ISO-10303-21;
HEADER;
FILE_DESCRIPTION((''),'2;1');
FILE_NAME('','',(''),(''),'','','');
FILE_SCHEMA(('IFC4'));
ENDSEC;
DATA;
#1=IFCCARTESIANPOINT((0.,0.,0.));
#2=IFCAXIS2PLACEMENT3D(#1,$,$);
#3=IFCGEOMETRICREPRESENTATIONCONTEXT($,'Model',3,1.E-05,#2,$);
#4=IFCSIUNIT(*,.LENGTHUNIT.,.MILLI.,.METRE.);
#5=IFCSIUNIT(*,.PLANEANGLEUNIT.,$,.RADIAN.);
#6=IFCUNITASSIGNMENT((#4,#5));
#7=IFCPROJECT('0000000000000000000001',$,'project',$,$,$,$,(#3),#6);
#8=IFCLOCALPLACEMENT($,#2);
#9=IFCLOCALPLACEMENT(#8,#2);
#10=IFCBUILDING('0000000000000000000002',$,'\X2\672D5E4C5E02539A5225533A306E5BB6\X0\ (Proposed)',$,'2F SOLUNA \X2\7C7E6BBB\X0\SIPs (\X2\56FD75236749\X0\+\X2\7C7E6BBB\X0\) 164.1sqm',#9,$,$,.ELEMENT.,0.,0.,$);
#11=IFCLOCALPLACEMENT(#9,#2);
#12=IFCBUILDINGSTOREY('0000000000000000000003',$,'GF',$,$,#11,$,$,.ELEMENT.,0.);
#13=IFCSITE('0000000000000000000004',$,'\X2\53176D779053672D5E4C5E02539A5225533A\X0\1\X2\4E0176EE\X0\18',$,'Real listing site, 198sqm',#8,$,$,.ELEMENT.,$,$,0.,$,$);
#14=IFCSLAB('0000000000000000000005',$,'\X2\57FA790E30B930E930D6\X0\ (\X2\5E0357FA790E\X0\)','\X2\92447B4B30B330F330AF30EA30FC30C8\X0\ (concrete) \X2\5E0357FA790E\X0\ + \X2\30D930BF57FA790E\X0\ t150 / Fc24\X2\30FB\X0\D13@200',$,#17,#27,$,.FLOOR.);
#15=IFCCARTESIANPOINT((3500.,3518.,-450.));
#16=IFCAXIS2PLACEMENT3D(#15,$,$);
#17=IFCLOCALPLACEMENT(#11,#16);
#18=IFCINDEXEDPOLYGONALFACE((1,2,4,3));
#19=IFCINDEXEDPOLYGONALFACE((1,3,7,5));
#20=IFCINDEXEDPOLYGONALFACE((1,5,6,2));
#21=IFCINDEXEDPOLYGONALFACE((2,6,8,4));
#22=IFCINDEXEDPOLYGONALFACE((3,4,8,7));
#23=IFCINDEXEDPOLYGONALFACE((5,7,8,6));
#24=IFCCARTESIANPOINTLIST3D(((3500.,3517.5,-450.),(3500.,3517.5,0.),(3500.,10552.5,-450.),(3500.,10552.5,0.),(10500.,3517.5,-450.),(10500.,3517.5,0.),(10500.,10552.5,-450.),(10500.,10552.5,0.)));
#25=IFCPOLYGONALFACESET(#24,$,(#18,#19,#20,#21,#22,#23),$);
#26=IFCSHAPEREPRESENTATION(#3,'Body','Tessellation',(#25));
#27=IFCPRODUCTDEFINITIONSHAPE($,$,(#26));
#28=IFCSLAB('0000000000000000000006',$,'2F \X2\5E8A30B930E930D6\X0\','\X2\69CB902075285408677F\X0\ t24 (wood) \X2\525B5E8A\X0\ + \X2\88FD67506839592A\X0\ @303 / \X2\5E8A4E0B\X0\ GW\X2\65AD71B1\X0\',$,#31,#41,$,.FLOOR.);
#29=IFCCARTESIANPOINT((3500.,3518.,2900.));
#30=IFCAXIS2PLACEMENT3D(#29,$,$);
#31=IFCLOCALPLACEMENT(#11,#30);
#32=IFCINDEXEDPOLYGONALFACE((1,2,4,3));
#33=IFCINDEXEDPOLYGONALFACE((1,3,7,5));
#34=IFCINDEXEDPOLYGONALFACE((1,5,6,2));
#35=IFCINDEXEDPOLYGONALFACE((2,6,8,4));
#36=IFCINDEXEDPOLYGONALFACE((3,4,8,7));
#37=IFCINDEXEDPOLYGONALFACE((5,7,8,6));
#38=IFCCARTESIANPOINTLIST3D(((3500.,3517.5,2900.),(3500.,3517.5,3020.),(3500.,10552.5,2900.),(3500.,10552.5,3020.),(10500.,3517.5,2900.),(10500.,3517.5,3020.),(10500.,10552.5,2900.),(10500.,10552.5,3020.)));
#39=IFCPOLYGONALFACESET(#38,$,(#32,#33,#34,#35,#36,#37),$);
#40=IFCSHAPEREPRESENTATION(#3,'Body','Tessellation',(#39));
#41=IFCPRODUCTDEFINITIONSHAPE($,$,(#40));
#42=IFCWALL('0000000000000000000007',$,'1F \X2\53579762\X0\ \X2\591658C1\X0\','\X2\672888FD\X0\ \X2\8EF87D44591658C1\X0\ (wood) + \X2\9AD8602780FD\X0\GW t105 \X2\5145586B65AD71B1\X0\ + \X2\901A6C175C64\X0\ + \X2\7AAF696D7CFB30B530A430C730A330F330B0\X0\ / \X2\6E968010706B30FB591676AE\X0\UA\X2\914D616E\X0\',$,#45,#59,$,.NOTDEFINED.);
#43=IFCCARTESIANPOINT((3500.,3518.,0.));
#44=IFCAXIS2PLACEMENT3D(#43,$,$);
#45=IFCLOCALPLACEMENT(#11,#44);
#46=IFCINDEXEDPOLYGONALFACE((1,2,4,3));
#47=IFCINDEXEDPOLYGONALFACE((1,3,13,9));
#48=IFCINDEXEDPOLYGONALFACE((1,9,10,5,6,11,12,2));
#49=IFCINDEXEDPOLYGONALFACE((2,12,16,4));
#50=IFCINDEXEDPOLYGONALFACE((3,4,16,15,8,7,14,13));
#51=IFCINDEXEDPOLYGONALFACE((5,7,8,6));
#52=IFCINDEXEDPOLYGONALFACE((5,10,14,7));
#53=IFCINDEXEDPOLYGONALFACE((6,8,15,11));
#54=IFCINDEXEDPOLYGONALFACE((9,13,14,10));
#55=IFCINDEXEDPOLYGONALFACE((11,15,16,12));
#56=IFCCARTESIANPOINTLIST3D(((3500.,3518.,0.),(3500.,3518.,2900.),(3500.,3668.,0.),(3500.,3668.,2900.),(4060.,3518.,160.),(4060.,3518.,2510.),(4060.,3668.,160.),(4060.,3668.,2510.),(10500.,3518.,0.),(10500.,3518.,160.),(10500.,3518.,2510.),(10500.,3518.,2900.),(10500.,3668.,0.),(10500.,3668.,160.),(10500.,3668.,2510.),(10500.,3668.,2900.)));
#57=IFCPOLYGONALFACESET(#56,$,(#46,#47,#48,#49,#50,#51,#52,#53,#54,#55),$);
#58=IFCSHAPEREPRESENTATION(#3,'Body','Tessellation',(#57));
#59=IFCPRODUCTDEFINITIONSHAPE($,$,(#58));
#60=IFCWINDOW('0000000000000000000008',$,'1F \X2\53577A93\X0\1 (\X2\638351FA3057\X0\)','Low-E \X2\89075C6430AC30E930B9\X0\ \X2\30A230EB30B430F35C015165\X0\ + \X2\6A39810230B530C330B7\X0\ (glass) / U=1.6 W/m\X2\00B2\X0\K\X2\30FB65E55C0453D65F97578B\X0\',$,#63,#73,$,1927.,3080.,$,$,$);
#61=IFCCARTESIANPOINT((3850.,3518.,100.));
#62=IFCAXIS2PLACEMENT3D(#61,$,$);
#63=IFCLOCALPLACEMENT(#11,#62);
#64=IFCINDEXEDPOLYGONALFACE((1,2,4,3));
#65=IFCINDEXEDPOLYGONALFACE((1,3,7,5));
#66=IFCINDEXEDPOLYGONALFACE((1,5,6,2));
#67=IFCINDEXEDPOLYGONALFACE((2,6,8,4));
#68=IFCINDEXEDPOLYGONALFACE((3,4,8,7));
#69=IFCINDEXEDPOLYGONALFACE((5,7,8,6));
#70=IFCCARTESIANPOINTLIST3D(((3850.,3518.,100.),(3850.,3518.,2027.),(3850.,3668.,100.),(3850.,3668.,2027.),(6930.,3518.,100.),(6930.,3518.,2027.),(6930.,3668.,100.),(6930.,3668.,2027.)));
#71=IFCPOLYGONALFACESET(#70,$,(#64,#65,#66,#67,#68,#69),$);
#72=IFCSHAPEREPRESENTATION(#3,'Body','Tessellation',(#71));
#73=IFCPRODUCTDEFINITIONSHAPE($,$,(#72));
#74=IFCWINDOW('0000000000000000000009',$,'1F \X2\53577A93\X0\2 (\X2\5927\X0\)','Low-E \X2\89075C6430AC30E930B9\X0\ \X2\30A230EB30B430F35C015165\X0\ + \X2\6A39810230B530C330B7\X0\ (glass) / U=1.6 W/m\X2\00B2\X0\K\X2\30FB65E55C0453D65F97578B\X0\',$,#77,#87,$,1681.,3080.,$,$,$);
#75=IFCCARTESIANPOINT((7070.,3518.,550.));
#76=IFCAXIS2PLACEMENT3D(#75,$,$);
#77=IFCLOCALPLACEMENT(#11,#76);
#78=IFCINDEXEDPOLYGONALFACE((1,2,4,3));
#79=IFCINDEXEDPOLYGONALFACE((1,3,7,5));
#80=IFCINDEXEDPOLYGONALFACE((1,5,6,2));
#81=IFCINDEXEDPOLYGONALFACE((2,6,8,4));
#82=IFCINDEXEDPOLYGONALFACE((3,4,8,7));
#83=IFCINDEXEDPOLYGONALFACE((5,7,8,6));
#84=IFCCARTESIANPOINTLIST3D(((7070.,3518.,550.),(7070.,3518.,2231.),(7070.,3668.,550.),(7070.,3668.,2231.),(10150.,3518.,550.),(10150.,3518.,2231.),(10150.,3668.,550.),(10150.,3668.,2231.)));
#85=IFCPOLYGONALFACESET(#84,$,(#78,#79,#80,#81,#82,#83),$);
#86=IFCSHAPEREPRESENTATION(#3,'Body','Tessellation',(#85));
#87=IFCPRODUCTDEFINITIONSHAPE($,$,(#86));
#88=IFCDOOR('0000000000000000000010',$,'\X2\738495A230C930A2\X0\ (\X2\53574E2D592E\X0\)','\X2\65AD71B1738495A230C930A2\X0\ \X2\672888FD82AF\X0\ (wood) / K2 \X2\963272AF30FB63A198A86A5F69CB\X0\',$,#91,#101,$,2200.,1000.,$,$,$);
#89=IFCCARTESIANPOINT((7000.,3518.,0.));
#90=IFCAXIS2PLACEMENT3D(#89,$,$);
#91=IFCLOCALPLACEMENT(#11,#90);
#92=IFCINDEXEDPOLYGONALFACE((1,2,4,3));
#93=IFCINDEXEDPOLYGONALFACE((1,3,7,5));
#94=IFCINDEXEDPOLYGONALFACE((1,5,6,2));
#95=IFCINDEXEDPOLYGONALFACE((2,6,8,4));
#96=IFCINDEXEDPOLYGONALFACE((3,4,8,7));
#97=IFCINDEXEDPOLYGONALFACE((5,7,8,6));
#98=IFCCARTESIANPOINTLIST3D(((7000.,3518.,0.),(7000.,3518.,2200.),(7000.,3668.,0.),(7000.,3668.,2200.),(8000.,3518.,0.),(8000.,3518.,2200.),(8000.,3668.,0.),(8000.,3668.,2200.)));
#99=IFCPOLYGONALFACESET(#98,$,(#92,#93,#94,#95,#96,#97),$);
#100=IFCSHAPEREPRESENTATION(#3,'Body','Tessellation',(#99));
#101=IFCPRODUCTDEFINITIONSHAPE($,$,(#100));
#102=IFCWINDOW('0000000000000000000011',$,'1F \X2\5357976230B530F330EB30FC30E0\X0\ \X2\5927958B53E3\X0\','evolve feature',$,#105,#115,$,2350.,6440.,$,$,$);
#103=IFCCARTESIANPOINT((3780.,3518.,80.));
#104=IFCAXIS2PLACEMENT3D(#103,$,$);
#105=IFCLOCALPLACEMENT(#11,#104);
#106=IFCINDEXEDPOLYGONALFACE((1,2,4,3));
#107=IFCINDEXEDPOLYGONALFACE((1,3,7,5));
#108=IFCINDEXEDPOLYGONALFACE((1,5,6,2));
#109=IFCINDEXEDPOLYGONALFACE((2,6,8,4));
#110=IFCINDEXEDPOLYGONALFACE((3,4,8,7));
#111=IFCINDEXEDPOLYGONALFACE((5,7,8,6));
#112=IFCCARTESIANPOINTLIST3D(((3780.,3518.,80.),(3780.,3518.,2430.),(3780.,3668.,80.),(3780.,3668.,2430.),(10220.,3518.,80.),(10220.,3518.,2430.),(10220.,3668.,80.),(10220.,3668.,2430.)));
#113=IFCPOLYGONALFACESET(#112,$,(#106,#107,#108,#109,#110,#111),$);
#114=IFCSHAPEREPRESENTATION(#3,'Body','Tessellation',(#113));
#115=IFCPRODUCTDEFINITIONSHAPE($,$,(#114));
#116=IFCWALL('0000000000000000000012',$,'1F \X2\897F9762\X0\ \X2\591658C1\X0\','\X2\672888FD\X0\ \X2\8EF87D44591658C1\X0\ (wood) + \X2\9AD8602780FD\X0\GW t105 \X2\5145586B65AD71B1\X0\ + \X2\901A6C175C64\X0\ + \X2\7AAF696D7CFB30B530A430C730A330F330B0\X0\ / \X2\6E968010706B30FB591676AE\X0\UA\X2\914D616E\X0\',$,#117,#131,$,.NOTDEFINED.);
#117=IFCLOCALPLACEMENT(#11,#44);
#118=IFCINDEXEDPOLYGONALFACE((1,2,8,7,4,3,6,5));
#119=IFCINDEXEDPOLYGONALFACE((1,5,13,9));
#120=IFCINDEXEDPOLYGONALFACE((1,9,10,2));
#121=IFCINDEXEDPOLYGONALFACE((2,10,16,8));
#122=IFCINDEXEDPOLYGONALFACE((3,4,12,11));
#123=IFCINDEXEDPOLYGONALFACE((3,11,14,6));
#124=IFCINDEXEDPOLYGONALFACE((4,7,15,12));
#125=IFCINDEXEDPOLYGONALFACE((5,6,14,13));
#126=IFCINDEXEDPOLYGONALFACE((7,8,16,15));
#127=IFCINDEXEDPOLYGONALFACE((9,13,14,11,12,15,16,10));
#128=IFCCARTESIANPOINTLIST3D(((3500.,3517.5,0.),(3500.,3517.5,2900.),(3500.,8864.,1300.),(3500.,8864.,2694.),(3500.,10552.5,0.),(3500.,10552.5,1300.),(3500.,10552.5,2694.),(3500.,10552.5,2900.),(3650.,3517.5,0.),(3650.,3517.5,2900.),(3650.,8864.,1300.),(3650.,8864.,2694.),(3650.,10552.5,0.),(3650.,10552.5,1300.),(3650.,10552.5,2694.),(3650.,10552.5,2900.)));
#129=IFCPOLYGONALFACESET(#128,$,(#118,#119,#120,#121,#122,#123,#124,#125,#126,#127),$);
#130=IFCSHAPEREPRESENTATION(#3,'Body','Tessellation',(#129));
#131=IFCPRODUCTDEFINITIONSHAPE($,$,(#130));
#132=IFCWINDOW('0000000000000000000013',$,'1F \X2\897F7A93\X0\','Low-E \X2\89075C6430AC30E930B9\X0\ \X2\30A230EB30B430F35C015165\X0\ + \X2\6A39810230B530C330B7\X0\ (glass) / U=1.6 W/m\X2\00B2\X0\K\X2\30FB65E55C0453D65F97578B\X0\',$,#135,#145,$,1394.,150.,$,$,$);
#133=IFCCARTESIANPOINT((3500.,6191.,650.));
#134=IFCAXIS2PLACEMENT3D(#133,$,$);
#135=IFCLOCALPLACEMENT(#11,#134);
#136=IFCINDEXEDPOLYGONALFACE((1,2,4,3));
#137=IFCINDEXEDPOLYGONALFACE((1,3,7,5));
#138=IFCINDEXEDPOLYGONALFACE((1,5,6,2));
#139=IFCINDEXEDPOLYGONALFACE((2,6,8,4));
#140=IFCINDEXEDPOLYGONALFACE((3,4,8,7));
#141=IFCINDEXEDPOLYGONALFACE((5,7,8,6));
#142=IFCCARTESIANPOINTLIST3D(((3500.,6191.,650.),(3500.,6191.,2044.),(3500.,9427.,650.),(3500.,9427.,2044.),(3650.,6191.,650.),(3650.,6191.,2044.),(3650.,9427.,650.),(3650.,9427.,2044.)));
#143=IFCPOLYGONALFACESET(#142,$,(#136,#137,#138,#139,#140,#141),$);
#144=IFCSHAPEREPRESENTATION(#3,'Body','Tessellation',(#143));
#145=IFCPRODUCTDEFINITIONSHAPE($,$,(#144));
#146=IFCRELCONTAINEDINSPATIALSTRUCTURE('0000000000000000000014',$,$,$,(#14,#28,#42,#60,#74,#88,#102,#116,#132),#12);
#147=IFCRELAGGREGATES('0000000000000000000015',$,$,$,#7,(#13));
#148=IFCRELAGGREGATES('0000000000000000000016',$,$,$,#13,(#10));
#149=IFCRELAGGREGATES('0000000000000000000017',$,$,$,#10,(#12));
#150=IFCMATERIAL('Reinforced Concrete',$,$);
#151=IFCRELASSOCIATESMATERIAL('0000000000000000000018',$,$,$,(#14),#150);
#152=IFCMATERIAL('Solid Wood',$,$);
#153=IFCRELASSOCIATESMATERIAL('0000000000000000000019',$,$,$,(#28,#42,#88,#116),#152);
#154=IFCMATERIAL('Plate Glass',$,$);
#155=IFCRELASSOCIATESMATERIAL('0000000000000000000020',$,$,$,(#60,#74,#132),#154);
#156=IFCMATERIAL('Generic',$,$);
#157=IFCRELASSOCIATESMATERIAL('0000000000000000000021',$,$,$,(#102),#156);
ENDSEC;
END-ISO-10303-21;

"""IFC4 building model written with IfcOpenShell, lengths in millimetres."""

from ifc_helpers import new_model, si_unit, frame, frame_2d, origin, place, context, project, spatial, rectangle, extrude, material, element, fill, save


model = new_model("IFC4")

# Units and contexts
model_context = context("Model", 3, precision=1e-05, world=origin())
ifc_project = project(units=[si_unit("LENGTHUNIT", "METRE", prefix="MILLI"), si_unit("PLANEANGLEUNIT", "RADIAN")], contexts=[model_context])

# Site, building, storey
site_placement = place(None, origin())
site = spatial("IfcSite", under=ifc_project, at=site_placement, Name="北海道札幌市厚別区1丁目18", ObjectType="Real listing site, 198sqm", CompositionType="ELEMENT", RefElevation=0.0)
building_placement = place(site_placement, origin())
building = spatial("IfcBuilding", under=site, at=building_placement, Name="札幌市厚別区の家 (Proposed)", ObjectType="2F SOLUNA 籾殻SIPs (国産杉+籾殻) 164.1sqm", CompositionType="ELEMENT", ElevationOfRefHeight=0.0, ElevationOfTerrain=0.0)
storey_placement = place(building_placement, origin())
storey = spatial("IfcBuildingStorey", under=building, at=storey_placement, Name="GF", CompositionType="ELEMENT", Elevation=0.0)

# Slabs
ifc_material_1 = material(Name="Reinforced Concrete")
slab_1_placement = place(storey_placement, frame((3500.0, 3518.0, -450.0)))
element("IfcSlab", 1, at=slab_1_placement, inside=storey, material=ifc_material_1, Name="基礎スラブ (布基礎)", Description="鉄筋コンクリート (concrete) 布基礎 + ベタ基礎 t150 / Fc24・D13@200", PredefinedType="FLOOR", context=model_context, shape_type="SweptSolid", body=[
    extrude(rectangle(XDim=7000.0, YDim=7035.0, at=frame_2d((3500.0, 3517.0))), frame((3500.0, 3518.0, -450.0)), (0.0, 0.0, 1.0), 450.0),
])
ifc_material_2 = material(Name="Solid Wood")
slab_2_placement = place(storey_placement, frame((3500.0, 3518.0, 2900.0)))
element("IfcSlab", 2, at=slab_2_placement, inside=storey, material=ifc_material_2, Name="2F 床スラブ", Description="構造用合板 t24 (wood) 剛床 + 製材根太 @303 / 床下 GW断熱", PredefinedType="FLOOR", context=model_context, shape_type="SweptSolid", body=[
    extrude(rectangle(XDim=7000.0, YDim=7035.0, at=frame_2d((3500.0, 3517.0))), frame((3500.0, 3518.0, 2900.0)), (0.0, 0.0, 1.0), 120.0),
])
ifc_material_3 = material(Name="Generic")

# Wall, openings, windows, door
wall_1_placement = place(storey_placement, frame((3500.0, 3518.0, 0.0)))
wall_1 = element("IfcWall", 3, at=wall_1_placement, inside=storey, material=ifc_material_2, Name="1F 南面 外壁", Description="木製 軸組外壁 (wood) + 高性能GW t105 充填断熱 + 通気層 + 窯業系サイディング / 準耐火・外皮UA配慮", PredefinedType="NOTDEFINED", context=model_context, shape_type="SweptSolid", body=[
    extrude(rectangle(XDim=7000.0, YDim=150.0, at=frame_2d((3500.0, 75.0))), frame((3500.0, 3518.0, 0.0)), (0.0, 0.0, 1.0), 2900.0),
])
opening_1_placement = place(storey_placement, frame((3850.0, 3518.0, 100.0)))
opening_1 = element("IfcOpeningElement", 4, at=opening_1_placement, cuts=wall_1, PredefinedType="NOTDEFINED", context=model_context, shape_type="SweptSolid", body=[
    extrude(rectangle(XDim=3080.0, YDim=150.0, at=frame_2d((1540.0, 75.0))), frame((3850.0, 3518.0, 100.0)), (0.0, 0.0, 1.0), 1927.0),
])
opening_2_placement = place(storey_placement, frame((7070.0, 3518.0, 550.0)))
opening_2 = element("IfcOpeningElement", 5, at=opening_2_placement, cuts=wall_1, PredefinedType="NOTDEFINED", context=model_context, shape_type="SweptSolid", body=[
    extrude(rectangle(XDim=3080.0, YDim=150.0, at=frame_2d((1540.0, 75.0))), frame((7070.0, 3518.0, 550.0)), (0.0, 0.0, 1.0), 1681.0),
])
opening_3_placement = place(storey_placement, frame((7000.0, 3518.0, 0.0)))
opening_3 = element("IfcOpeningElement", 6, at=opening_3_placement, cuts=wall_1, PredefinedType="NOTDEFINED", context=model_context, shape_type="SweptSolid", body=[
    extrude(rectangle(XDim=1000.0, YDim=150.0, at=frame_2d((500.0, 75.0))), frame((7000.0, 3518.0, 0.0)), (0.0, 0.0, 1.0), 2200.0),
])
opening_4_placement = place(storey_placement, frame((3780.0, 3518.0, 80.0)))
opening_4 = element("IfcOpeningElement", 7, at=opening_4_placement, cuts=wall_1, PredefinedType="NOTDEFINED", context=model_context, shape_type="SweptSolid", body=[
    extrude(rectangle(XDim=6440.0, YDim=150.0, at=frame_2d((3220.0, 75.0))), frame((3780.0, 3518.0, 80.0)), (0.0, 0.0, 1.0), 2350.0),
])
ifc_material_4 = material(Name="Plate Glass")
window_1_placement = place(storey_placement, frame((3850.0, 3518.0, 100.0)))
window_1 = element("IfcWindow", 8, at=window_1_placement, inside=storey, material=ifc_material_4, Name="1F 南窓1 (掃出し)", Description="Low-E 複層ガラス アルゴン封入 + 樹脂サッシ (glass) / U=1.6 W/m²K・日射取得型", OverallHeight=1927.0, OverallWidth=3080.0, context=model_context, shape_type="SweptSolid", body=[
    extrude(rectangle(XDim=3080.0, YDim=150.0, at=frame_2d((1540.0, 75.0))), frame((3850.0, 3518.0, 100.0)), (0.0, 0.0, 1.0), 1927.0),
])
fill(opening_1, window_1)
window_2_placement = place(storey_placement, frame((7070.0, 3518.0, 550.0)))
window_2 = element("IfcWindow", 9, at=window_2_placement, inside=storey, material=ifc_material_4, Name="1F 南窓2 (大)", Description="Low-E 複層ガラス アルゴン封入 + 樹脂サッシ (glass) / U=1.6 W/m²K・日射取得型", OverallHeight=1681.0, OverallWidth=3080.0, context=model_context, shape_type="SweptSolid", body=[
    extrude(rectangle(XDim=3080.0, YDim=150.0, at=frame_2d((1540.0, 75.0))), frame((7070.0, 3518.0, 550.0)), (0.0, 0.0, 1.0), 1681.0),
])
fill(opening_2, window_2)
door_placement = place(storey_placement, frame((7000.0, 3518.0, 0.0)))
door = element("IfcDoor", 10, at=door_placement, inside=storey, material=ifc_material_2, Name="玄関ドア (南中央)", Description="断熱玄関ドア 木製芯 (wood) / K2 防犯・採風機構", OverallHeight=2200.0, OverallWidth=1000.0, context=model_context, shape_type="SweptSolid", body=[
    extrude(rectangle(XDim=1000.0, YDim=150.0, at=frame_2d((500.0, 75.0))), frame((7000.0, 3518.0, 0.0)), (0.0, 0.0, 1.0), 2200.0),
])
fill(opening_3, door)
window_3_placement = place(storey_placement, frame((3780.0, 3518.0, 80.0)))
window_3 = element("IfcWindow", 11, at=window_3_placement, inside=storey, material=ifc_material_3, Name="1F 南面サンルーム 大開口", Description="evolve feature", OverallHeight=2350.0, OverallWidth=6440.0, context=model_context, shape_type="SweptSolid", body=[
    extrude(rectangle(XDim=6440.0, YDim=150.0, at=frame_2d((3220.0, 75.0))), frame((3780.0, 3518.0, 80.0)), (0.0, 0.0, 1.0), 2350.0),
])
fill(opening_4, window_3)

# Wall, opening, window
wall_2_placement = place(storey_placement, frame((3500.0, 3518.0, 0.0)))
wall_2 = element("IfcWall", 12, at=wall_2_placement, inside=storey, material=ifc_material_2, Name="1F 西面 外壁", Description="木製 軸組外壁 (wood) + 高性能GW t105 充填断熱 + 通気層 + 窯業系サイディング / 準耐火・外皮UA配慮", PredefinedType="NOTDEFINED", context=model_context, shape_type="SweptSolid", body=[
    extrude(rectangle(XDim=150.0, YDim=7035.0, at=frame_2d((75.0, 3517.0))), frame((3500.0, 3518.0, 0.0)), (0.0, 0.0, 1.0), 2900.0),
])
opening_5_placement = place(storey_placement, frame((3500.0, 6191.0, 650.0)))
opening_5 = element("IfcOpeningElement", 13, at=opening_5_placement, cuts=wall_2, PredefinedType="NOTDEFINED", context=model_context, shape_type="SweptSolid", body=[
    extrude(rectangle(XDim=150.0, YDim=3236.0, at=frame_2d((75.0, 1618.0))), frame((3500.0, 6191.0, 650.0)), (0.0, 0.0, 1.0), 1394.0),
])
window_4_placement = place(storey_placement, frame((3500.0, 6191.0, 650.0)))
window_4 = element("IfcWindow", 14, at=window_4_placement, inside=storey, material=ifc_material_4, Name="1F 西窓", Description="Low-E 複層ガラス アルゴン封入 + 樹脂サッシ (glass) / U=1.6 W/m²K・日射取得型", OverallHeight=1394.0, OverallWidth=150.0, context=model_context, shape_type="SweptSolid", body=[
    extrude(rectangle(XDim=150.0, YDim=3236.0, at=frame_2d((75.0, 1618.0))), frame((3500.0, 6191.0, 650.0)), (0.0, 0.0, 1.0), 1394.0),
])
fill(opening_5, window_4)

save(model, "model.ifc")
